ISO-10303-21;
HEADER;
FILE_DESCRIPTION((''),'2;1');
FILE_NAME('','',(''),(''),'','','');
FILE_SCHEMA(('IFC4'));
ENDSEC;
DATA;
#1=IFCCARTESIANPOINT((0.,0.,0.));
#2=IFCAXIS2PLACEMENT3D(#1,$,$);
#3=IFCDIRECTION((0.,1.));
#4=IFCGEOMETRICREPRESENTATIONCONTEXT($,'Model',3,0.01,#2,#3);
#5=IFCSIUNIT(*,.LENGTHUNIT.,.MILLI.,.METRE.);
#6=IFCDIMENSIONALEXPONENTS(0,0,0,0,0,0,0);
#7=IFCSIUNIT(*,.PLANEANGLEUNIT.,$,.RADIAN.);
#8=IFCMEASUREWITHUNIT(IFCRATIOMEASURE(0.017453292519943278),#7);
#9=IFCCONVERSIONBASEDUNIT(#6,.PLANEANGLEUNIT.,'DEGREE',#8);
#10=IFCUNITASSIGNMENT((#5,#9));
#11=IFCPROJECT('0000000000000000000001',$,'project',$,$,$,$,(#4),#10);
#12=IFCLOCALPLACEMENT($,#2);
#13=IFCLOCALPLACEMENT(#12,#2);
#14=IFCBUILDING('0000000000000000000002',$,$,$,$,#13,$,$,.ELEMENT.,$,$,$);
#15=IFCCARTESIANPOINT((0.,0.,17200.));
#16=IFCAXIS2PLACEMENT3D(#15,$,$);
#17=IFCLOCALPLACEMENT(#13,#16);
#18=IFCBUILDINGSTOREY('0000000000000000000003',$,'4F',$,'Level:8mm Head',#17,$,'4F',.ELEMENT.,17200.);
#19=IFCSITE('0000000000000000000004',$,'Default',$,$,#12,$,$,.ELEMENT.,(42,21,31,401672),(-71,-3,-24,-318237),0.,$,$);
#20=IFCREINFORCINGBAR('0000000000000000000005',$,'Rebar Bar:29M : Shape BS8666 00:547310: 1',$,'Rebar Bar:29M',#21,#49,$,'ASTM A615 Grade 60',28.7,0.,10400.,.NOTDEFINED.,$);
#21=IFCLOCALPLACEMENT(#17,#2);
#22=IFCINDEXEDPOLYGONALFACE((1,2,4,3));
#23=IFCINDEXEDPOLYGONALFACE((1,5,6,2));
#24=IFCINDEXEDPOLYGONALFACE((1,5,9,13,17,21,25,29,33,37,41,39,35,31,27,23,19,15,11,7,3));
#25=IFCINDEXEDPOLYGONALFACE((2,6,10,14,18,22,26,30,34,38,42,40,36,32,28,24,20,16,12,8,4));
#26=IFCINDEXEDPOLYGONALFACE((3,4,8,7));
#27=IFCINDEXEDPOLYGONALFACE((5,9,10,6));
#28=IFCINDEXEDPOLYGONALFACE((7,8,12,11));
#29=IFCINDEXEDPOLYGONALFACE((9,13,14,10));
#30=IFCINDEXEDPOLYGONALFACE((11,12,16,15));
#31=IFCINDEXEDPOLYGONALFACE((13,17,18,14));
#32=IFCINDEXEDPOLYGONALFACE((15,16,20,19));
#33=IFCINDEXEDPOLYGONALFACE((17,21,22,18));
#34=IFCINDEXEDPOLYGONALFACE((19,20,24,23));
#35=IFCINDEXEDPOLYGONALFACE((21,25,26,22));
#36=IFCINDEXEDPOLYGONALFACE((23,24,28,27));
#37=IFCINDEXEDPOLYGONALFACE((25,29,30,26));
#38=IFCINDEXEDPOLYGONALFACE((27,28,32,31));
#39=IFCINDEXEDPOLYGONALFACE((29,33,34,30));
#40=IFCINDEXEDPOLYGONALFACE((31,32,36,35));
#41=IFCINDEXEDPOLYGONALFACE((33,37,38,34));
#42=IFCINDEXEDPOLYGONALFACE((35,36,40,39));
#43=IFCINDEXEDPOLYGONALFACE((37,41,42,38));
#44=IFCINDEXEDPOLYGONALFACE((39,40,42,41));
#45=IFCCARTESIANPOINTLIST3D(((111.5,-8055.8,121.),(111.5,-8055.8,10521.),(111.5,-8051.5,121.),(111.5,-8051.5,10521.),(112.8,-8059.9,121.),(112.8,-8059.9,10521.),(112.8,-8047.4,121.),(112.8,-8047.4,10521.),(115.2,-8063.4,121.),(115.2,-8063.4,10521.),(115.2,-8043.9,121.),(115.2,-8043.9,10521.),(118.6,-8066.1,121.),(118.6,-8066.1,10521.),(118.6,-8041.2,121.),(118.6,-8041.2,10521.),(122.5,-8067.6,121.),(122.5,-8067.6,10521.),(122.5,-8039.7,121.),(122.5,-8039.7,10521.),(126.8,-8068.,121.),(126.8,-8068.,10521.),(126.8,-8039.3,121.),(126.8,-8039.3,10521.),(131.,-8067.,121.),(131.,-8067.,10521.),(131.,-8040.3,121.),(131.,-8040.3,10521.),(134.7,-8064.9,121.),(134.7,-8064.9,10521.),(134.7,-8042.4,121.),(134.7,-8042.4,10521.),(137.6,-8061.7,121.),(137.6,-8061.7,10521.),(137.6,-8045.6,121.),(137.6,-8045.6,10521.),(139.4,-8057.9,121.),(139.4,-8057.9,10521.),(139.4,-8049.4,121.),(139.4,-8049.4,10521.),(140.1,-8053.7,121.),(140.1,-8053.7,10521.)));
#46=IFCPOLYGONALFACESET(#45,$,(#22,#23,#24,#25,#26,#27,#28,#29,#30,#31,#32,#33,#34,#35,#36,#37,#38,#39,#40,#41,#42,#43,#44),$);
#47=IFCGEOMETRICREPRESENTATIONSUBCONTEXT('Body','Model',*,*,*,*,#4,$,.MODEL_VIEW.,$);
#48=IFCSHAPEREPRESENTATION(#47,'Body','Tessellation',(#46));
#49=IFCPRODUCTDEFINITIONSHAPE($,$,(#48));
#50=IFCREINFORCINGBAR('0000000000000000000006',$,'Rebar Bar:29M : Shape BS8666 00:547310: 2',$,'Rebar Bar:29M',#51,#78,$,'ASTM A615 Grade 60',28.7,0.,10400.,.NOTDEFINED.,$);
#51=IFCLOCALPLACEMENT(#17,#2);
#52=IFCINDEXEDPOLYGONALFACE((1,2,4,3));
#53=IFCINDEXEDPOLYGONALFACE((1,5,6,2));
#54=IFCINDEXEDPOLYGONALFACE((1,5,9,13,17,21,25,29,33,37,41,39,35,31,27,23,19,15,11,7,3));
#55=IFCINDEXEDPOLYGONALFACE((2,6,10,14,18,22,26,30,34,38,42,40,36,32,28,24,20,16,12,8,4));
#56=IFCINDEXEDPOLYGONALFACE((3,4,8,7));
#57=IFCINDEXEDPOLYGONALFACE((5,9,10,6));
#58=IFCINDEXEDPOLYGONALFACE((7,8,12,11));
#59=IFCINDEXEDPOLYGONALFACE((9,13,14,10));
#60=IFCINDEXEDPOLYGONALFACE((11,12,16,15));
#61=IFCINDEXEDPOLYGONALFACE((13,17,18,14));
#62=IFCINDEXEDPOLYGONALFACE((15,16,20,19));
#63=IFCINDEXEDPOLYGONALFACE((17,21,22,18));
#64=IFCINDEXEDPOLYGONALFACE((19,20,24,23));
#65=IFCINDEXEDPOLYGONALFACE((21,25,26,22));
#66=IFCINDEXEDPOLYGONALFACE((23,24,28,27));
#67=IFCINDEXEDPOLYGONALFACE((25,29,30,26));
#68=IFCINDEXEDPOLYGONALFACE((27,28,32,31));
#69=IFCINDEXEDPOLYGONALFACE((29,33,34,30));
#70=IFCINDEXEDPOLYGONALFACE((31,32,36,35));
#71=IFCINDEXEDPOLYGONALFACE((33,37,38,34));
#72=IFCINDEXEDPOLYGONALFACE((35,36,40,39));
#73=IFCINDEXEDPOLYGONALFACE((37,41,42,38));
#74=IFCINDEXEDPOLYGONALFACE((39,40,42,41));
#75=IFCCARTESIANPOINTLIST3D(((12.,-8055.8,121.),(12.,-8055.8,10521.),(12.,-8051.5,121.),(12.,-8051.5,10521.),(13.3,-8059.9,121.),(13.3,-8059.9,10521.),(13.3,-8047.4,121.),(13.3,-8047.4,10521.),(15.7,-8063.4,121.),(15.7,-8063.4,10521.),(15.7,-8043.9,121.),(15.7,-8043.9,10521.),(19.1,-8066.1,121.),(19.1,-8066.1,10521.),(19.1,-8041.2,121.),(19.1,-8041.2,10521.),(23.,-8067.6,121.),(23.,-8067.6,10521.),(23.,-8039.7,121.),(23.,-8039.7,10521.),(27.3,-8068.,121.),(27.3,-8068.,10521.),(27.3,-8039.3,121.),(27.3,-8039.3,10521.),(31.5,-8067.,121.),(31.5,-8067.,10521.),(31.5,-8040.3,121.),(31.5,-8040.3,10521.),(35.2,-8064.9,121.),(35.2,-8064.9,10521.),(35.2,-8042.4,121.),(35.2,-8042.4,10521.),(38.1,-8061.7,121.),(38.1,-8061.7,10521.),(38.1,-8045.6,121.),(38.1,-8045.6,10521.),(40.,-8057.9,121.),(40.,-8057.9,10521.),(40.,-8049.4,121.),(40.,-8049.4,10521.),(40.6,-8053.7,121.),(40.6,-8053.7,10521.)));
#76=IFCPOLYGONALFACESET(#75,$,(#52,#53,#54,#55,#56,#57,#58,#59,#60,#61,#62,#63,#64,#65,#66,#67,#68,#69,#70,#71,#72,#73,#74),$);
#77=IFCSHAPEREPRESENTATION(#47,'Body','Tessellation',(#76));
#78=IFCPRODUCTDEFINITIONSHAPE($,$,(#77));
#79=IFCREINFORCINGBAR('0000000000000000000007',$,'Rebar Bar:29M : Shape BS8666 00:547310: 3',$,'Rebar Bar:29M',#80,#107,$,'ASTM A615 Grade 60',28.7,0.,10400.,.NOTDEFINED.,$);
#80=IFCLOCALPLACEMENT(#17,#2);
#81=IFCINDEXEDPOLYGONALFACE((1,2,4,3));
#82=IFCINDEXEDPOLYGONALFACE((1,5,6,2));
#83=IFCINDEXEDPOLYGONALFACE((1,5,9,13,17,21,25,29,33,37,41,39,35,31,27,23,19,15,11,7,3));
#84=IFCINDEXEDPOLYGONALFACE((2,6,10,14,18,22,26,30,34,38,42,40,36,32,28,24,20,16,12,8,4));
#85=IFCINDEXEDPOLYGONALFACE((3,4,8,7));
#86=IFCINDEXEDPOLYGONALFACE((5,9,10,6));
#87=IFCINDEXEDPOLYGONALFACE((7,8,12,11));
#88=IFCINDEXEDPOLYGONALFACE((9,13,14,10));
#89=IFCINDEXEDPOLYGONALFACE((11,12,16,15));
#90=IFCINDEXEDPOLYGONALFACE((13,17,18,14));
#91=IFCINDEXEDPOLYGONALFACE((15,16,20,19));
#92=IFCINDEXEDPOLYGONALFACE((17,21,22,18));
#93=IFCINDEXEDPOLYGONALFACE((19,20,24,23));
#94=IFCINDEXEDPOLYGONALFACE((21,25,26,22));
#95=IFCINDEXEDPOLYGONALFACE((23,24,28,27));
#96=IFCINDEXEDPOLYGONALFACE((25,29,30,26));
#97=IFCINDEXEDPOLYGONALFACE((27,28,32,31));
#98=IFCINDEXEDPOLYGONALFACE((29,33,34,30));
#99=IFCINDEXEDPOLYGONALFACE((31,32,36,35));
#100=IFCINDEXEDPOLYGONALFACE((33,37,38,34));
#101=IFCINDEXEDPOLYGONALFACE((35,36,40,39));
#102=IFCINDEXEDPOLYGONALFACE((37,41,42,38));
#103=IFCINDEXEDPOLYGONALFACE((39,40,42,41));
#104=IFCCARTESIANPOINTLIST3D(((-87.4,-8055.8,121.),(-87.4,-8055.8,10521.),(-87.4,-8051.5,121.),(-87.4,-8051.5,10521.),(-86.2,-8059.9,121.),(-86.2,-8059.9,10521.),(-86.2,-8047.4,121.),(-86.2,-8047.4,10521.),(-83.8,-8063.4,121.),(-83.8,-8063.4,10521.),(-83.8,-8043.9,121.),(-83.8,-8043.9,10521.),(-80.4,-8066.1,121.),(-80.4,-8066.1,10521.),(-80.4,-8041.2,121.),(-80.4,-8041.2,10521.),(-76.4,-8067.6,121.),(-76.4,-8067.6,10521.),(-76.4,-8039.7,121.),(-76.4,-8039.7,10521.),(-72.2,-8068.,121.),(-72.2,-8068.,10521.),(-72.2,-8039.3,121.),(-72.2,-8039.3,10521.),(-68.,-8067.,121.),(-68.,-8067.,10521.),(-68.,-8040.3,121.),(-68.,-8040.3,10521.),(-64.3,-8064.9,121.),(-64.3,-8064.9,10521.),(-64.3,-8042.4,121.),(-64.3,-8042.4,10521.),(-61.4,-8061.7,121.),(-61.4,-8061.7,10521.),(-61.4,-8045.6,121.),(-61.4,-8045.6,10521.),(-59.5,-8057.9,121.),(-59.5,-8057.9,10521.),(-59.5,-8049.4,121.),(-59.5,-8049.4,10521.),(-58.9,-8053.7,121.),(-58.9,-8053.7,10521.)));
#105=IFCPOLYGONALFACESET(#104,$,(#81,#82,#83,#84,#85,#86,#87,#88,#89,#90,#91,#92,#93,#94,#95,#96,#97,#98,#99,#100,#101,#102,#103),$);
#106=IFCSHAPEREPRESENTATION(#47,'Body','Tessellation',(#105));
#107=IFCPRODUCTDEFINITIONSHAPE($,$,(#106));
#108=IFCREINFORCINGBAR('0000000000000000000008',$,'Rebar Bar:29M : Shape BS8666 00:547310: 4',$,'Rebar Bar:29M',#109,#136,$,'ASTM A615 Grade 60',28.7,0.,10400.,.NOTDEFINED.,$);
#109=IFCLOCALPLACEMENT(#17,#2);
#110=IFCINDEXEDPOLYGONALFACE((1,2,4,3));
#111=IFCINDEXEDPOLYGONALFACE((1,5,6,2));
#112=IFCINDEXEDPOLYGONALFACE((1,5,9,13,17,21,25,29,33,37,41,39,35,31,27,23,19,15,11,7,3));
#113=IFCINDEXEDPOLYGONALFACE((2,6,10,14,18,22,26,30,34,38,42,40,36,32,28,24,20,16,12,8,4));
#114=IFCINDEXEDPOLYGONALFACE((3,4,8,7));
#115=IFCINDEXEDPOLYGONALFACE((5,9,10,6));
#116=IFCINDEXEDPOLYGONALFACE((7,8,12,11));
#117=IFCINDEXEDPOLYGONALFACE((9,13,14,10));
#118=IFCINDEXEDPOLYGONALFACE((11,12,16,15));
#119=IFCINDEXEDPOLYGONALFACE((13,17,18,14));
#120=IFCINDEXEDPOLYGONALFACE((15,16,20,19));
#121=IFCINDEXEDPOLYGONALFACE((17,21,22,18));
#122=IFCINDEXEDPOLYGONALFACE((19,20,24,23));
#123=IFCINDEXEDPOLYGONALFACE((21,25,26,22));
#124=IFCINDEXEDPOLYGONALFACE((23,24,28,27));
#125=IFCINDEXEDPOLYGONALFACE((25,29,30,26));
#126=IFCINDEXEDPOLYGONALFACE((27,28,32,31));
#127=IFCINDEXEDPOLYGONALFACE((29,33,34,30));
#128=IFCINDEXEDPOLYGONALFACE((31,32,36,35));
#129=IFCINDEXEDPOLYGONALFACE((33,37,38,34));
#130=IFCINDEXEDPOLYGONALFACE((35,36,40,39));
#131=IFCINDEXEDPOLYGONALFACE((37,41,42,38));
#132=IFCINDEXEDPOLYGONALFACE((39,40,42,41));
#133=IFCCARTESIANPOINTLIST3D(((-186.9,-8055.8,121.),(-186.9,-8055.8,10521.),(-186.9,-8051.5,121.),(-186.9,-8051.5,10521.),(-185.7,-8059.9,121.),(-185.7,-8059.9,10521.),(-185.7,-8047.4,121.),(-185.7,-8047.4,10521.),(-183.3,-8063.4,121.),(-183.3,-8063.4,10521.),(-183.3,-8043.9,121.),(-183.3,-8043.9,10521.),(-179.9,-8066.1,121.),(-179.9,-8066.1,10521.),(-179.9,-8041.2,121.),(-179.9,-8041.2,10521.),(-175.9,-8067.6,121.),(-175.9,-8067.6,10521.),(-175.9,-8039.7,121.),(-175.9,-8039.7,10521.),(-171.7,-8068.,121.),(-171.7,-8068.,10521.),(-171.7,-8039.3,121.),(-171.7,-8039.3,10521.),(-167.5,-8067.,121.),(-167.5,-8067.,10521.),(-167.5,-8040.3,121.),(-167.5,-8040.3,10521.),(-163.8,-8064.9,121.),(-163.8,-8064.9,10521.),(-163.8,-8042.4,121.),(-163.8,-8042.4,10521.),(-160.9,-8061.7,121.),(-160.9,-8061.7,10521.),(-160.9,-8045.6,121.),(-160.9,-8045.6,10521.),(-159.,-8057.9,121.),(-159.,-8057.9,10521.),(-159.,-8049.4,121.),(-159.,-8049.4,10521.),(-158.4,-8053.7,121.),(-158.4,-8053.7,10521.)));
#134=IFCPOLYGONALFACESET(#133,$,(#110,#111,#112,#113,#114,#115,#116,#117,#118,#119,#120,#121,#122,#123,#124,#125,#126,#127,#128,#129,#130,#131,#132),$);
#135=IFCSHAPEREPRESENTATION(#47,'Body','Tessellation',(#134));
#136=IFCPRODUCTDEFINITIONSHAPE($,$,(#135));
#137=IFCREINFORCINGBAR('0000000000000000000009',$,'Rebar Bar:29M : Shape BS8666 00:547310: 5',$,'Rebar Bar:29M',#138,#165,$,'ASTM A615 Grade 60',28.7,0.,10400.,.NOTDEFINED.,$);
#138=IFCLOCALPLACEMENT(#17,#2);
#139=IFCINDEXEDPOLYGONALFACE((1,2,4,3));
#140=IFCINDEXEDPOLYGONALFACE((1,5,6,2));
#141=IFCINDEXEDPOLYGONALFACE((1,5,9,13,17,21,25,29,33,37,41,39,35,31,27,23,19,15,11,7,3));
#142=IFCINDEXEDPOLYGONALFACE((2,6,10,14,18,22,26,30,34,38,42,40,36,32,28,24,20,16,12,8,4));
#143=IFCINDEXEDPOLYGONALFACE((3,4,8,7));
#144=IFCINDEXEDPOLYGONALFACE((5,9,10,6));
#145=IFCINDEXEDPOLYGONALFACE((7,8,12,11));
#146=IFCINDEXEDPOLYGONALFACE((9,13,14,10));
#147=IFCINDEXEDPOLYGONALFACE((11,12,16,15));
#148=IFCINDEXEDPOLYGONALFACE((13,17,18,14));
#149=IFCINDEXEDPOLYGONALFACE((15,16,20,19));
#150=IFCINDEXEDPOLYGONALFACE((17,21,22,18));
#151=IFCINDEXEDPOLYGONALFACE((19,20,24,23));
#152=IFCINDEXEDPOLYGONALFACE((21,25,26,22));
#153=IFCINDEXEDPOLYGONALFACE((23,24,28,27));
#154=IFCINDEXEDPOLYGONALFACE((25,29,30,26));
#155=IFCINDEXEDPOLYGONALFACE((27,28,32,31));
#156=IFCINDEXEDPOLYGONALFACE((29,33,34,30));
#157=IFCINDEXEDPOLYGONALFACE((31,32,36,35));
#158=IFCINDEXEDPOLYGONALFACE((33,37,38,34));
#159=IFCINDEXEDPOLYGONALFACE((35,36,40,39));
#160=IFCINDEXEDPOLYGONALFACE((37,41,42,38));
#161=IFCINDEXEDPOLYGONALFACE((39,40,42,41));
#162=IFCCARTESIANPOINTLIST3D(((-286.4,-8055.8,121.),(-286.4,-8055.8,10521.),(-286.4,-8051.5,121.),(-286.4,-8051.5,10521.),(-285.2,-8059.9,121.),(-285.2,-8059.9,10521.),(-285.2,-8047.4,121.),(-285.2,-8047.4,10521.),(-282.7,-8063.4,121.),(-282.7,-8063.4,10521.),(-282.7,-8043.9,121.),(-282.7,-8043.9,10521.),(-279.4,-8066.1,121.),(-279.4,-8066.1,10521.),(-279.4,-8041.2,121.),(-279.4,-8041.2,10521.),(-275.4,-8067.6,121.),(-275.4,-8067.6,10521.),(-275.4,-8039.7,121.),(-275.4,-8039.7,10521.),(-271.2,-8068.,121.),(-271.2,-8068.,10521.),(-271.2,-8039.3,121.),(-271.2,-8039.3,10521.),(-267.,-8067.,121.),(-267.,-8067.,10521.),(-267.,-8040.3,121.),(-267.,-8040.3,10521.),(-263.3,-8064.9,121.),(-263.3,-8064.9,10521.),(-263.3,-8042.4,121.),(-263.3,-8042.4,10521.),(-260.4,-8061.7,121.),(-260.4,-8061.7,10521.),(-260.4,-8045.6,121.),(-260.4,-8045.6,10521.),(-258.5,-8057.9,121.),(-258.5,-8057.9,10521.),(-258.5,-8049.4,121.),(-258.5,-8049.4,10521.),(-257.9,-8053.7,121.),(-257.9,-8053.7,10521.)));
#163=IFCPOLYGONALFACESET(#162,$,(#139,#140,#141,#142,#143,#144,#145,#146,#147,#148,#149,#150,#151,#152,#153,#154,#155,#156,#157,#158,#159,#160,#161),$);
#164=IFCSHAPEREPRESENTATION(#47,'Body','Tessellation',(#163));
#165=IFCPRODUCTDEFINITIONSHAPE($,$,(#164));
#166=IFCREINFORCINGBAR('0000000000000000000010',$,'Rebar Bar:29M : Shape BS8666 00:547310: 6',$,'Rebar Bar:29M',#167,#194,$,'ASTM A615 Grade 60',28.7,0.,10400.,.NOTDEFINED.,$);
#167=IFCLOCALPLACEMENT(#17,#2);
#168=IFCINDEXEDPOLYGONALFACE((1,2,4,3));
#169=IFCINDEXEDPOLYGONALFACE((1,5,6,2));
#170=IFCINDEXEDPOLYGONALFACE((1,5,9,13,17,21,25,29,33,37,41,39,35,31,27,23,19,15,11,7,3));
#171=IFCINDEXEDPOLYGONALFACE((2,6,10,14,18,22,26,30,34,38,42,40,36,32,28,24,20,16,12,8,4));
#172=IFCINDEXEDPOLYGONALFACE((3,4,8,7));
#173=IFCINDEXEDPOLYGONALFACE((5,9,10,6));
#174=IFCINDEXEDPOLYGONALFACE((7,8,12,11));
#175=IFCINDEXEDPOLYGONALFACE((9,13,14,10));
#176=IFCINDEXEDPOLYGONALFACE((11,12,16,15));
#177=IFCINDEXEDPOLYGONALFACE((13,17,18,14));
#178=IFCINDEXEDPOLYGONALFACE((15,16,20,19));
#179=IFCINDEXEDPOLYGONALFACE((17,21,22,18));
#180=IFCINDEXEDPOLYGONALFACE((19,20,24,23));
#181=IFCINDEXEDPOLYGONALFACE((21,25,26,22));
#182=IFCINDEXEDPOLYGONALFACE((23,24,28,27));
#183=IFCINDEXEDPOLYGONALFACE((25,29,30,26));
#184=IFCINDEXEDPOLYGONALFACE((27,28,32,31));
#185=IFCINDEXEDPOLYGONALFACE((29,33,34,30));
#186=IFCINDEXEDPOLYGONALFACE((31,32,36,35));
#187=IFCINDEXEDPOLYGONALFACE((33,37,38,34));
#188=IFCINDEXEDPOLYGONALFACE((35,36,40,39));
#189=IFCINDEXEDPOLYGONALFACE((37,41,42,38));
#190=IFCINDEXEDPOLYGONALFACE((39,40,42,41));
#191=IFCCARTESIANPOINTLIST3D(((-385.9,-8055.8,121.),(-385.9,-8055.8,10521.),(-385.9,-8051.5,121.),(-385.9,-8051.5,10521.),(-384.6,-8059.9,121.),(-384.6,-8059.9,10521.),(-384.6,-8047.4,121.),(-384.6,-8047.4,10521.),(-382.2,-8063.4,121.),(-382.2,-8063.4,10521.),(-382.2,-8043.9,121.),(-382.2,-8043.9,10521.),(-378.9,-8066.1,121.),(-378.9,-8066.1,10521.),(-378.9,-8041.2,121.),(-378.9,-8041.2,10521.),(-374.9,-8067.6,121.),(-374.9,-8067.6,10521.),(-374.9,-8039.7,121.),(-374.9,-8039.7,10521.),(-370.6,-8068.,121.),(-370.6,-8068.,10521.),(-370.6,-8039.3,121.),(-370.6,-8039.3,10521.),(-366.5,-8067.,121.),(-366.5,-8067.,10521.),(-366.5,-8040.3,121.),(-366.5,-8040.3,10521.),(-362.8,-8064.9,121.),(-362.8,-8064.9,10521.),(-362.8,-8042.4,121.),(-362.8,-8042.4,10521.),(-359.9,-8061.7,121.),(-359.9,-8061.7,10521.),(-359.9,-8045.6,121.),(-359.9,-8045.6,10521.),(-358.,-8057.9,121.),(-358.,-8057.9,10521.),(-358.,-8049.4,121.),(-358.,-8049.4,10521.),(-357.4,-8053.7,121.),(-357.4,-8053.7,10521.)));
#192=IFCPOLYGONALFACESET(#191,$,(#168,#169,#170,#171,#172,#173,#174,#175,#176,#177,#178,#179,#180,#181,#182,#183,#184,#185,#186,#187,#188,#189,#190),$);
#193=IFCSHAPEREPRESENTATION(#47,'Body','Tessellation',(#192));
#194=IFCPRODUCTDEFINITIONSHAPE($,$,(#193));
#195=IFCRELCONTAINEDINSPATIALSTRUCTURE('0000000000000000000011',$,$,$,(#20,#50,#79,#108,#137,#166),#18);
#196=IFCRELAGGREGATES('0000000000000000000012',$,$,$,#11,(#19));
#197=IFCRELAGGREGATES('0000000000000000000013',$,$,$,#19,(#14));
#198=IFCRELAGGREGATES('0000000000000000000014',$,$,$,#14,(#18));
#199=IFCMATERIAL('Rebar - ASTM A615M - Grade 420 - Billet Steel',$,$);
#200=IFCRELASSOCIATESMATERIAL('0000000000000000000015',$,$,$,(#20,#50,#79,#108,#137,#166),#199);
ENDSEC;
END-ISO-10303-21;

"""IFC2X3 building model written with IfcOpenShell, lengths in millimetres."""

from ifc_helpers import new_model, entity, si_unit, converted_unit, direction, frame, origin, place, context, subcontext, project, spatial, material, element, save


model = new_model("IFC2X3")

# Units and contexts
model_context = context("Model", 3, precision=0.01, world=origin(), true_north=direction((0.0, 1.0)))
body_context = subcontext(model_context, "Body", "Model", "MODEL_VIEW")
ifc_project = project(units=[si_unit("LENGTHUNIT", "METRE", prefix="MILLI"), converted_unit("PLANEANGLEUNIT", "DEGREE", entity("IfcRatioMeasure", 0.017453292519943278), si_unit("PLANEANGLEUNIT", "RADIAN"), dimensions=[0, 0, 0, 0, 0, 0, 0])], contexts=[model_context])

# Site, building, storey
site_placement = place(None, origin())
site = spatial("IfcSite", under=ifc_project, at=site_placement, Name="Default", CompositionType="ELEMENT", RefLatitude=(42, 21, 31, 401672), RefLongitude=(-71, -3, -24, -318237), RefElevation=0.0)
building_placement = place(site_placement, origin())
building = spatial("IfcBuilding", under=site, at=building_placement, CompositionType="ELEMENT")
storey_placement = place(building_placement, frame((0.0, 0.0, 17200.0)))
storey = spatial("IfcBuildingStorey", under=building, at=storey_placement, Name="4F", ObjectType="Level:8mm Head", LongName="4F", CompositionType="ELEMENT", Elevation=17200.0)

# Reinforcing bars
ifc_material_1 = material(Name="Rebar - ASTM A615M - Grade 420 - Billet Steel")
reinforcing_bar_1_placement = place(storey_placement, origin())
element("IfcReinforcingBar", 1, at=reinforcing_bar_1_placement, inside=storey, material=ifc_material_1, Name="Rebar Bar:29M : Shape BS8666 00:547310: 1", SteelGrade="ASTM A615 Grade 60", ObjectType="Rebar Bar:29M", BarLength=10400.0, BarRole="NOTDEFINED", CrossSectionArea=0.0, NominalDiameter=28.7, context=body_context, shape_type="AdvancedSweptSolid", body=[
    entity("IfcSweptDiskSolid", entity("IfcCompositeCurve", [entity("IfcCompositeCurveSegment", "CONTINUOUS", True, entity("IfcPolyline", [entity("IfcCartesianPoint", [125.7, -8053.7, 121.0]), entity("IfcCartesianPoint", [125.7, -8053.7, 10521.0])]))], False), 14.3, None, 0.0, 1.0),
])
reinforcing_bar_2_placement = place(storey_placement, origin())
element("IfcReinforcingBar", 2, at=reinforcing_bar_2_placement, inside=storey, material=ifc_material_1, Name="Rebar Bar:29M : Shape BS8666 00:547310: 2", SteelGrade="ASTM A615 Grade 60", ObjectType="Rebar Bar:29M", BarLength=10400.0, BarRole="NOTDEFINED", CrossSectionArea=0.0, NominalDiameter=28.7, context=body_context, shape_type="AdvancedSweptSolid", body=[
    entity("IfcSweptDiskSolid", entity("IfcCompositeCurve", [entity("IfcCompositeCurveSegment", "CONTINUOUS", True, entity("IfcPolyline", [entity("IfcCartesianPoint", [26.2, -8053.7, 121.0]), entity("IfcCartesianPoint", [26.2, -8053.7, 10521.0])]))], False), 14.3, None, 0.0, 1.0),
])
reinforcing_bar_3_placement = place(storey_placement, origin())
element("IfcReinforcingBar", 3, at=reinforcing_bar_3_placement, inside=storey, material=ifc_material_1, Name="Rebar Bar:29M : Shape BS8666 00:547310: 3", SteelGrade="ASTM A615 Grade 60", ObjectType="Rebar Bar:29M", BarLength=10400.0, BarRole="NOTDEFINED", CrossSectionArea=0.0, NominalDiameter=28.7, context=body_context, shape_type="AdvancedSweptSolid", body=[
    entity("IfcSweptDiskSolid", entity("IfcCompositeCurve", [entity("IfcCompositeCurveSegment", "CONTINUOUS", True, entity("IfcPolyline", [entity("IfcCartesianPoint", [-73.3, -8053.7, 121.0]), entity("IfcCartesianPoint", [-73.3, -8053.7, 10521.0])]))], False), 14.3, None, 0.0, 1.0),
])
reinforcing_bar_4_placement = place(storey_placement, origin())
element("IfcReinforcingBar", 4, at=reinforcing_bar_4_placement, inside=storey, material=ifc_material_1, Name="Rebar Bar:29M : Shape BS8666 00:547310: 4", SteelGrade="ASTM A615 Grade 60", ObjectType="Rebar Bar:29M", BarLength=10400.0, BarRole="NOTDEFINED", CrossSectionArea=0.0, NominalDiameter=28.7, context=body_context, shape_type="AdvancedSweptSolid", body=[
    entity("IfcSweptDiskSolid", entity("IfcCompositeCurve", [entity("IfcCompositeCurveSegment", "CONTINUOUS", True, entity("IfcPolyline", [entity("IfcCartesianPoint", [-172.7, -8053.7, 121.0]), entity("IfcCartesianPoint", [-172.7, -8053.7, 10521.0])]))], False), 14.3, None, 0.0, 1.0),
])
reinforcing_bar_5_placement = place(storey_placement, origin())
element("IfcReinforcingBar", 5, at=reinforcing_bar_5_placement, inside=storey, material=ifc_material_1, Name="Rebar Bar:29M : Shape BS8666 00:547310: 5", SteelGrade="ASTM A615 Grade 60", ObjectType="Rebar Bar:29M", BarLength=10400.0, BarRole="NOTDEFINED", CrossSectionArea=0.0, NominalDiameter=28.7, context=body_context, shape_type="AdvancedSweptSolid", body=[
    entity("IfcSweptDiskSolid", entity("IfcCompositeCurve", [entity("IfcCompositeCurveSegment", "CONTINUOUS", True, entity("IfcPolyline", [entity("IfcCartesianPoint", [-272.2, -8053.7, 121.0]), entity("IfcCartesianPoint", [-272.2, -8053.7, 10521.0])]))], False), 14.3, None, 0.0, 1.0),
])
reinforcing_bar_6_placement = place(storey_placement, origin())
element("IfcReinforcingBar", 6, at=reinforcing_bar_6_placement, inside=storey, material=ifc_material_1, Name="Rebar Bar:29M : Shape BS8666 00:547310: 6", SteelGrade="ASTM A615 Grade 60", ObjectType="Rebar Bar:29M", BarLength=10400.0, BarRole="NOTDEFINED", CrossSectionArea=0.0, NominalDiameter=28.7, context=body_context, shape_type="AdvancedSweptSolid", body=[
    entity("IfcSweptDiskSolid", entity("IfcCompositeCurve", [entity("IfcCompositeCurveSegment", "CONTINUOUS", True, entity("IfcPolyline", [entity("IfcCartesianPoint", [-371.7, -8053.7, 121.0]), entity("IfcCartesianPoint", [-371.7, -8053.7, 10521.0])]))], False), 14.3, None, 0.0, 1.0),
])

save(model, "model.ifc")
